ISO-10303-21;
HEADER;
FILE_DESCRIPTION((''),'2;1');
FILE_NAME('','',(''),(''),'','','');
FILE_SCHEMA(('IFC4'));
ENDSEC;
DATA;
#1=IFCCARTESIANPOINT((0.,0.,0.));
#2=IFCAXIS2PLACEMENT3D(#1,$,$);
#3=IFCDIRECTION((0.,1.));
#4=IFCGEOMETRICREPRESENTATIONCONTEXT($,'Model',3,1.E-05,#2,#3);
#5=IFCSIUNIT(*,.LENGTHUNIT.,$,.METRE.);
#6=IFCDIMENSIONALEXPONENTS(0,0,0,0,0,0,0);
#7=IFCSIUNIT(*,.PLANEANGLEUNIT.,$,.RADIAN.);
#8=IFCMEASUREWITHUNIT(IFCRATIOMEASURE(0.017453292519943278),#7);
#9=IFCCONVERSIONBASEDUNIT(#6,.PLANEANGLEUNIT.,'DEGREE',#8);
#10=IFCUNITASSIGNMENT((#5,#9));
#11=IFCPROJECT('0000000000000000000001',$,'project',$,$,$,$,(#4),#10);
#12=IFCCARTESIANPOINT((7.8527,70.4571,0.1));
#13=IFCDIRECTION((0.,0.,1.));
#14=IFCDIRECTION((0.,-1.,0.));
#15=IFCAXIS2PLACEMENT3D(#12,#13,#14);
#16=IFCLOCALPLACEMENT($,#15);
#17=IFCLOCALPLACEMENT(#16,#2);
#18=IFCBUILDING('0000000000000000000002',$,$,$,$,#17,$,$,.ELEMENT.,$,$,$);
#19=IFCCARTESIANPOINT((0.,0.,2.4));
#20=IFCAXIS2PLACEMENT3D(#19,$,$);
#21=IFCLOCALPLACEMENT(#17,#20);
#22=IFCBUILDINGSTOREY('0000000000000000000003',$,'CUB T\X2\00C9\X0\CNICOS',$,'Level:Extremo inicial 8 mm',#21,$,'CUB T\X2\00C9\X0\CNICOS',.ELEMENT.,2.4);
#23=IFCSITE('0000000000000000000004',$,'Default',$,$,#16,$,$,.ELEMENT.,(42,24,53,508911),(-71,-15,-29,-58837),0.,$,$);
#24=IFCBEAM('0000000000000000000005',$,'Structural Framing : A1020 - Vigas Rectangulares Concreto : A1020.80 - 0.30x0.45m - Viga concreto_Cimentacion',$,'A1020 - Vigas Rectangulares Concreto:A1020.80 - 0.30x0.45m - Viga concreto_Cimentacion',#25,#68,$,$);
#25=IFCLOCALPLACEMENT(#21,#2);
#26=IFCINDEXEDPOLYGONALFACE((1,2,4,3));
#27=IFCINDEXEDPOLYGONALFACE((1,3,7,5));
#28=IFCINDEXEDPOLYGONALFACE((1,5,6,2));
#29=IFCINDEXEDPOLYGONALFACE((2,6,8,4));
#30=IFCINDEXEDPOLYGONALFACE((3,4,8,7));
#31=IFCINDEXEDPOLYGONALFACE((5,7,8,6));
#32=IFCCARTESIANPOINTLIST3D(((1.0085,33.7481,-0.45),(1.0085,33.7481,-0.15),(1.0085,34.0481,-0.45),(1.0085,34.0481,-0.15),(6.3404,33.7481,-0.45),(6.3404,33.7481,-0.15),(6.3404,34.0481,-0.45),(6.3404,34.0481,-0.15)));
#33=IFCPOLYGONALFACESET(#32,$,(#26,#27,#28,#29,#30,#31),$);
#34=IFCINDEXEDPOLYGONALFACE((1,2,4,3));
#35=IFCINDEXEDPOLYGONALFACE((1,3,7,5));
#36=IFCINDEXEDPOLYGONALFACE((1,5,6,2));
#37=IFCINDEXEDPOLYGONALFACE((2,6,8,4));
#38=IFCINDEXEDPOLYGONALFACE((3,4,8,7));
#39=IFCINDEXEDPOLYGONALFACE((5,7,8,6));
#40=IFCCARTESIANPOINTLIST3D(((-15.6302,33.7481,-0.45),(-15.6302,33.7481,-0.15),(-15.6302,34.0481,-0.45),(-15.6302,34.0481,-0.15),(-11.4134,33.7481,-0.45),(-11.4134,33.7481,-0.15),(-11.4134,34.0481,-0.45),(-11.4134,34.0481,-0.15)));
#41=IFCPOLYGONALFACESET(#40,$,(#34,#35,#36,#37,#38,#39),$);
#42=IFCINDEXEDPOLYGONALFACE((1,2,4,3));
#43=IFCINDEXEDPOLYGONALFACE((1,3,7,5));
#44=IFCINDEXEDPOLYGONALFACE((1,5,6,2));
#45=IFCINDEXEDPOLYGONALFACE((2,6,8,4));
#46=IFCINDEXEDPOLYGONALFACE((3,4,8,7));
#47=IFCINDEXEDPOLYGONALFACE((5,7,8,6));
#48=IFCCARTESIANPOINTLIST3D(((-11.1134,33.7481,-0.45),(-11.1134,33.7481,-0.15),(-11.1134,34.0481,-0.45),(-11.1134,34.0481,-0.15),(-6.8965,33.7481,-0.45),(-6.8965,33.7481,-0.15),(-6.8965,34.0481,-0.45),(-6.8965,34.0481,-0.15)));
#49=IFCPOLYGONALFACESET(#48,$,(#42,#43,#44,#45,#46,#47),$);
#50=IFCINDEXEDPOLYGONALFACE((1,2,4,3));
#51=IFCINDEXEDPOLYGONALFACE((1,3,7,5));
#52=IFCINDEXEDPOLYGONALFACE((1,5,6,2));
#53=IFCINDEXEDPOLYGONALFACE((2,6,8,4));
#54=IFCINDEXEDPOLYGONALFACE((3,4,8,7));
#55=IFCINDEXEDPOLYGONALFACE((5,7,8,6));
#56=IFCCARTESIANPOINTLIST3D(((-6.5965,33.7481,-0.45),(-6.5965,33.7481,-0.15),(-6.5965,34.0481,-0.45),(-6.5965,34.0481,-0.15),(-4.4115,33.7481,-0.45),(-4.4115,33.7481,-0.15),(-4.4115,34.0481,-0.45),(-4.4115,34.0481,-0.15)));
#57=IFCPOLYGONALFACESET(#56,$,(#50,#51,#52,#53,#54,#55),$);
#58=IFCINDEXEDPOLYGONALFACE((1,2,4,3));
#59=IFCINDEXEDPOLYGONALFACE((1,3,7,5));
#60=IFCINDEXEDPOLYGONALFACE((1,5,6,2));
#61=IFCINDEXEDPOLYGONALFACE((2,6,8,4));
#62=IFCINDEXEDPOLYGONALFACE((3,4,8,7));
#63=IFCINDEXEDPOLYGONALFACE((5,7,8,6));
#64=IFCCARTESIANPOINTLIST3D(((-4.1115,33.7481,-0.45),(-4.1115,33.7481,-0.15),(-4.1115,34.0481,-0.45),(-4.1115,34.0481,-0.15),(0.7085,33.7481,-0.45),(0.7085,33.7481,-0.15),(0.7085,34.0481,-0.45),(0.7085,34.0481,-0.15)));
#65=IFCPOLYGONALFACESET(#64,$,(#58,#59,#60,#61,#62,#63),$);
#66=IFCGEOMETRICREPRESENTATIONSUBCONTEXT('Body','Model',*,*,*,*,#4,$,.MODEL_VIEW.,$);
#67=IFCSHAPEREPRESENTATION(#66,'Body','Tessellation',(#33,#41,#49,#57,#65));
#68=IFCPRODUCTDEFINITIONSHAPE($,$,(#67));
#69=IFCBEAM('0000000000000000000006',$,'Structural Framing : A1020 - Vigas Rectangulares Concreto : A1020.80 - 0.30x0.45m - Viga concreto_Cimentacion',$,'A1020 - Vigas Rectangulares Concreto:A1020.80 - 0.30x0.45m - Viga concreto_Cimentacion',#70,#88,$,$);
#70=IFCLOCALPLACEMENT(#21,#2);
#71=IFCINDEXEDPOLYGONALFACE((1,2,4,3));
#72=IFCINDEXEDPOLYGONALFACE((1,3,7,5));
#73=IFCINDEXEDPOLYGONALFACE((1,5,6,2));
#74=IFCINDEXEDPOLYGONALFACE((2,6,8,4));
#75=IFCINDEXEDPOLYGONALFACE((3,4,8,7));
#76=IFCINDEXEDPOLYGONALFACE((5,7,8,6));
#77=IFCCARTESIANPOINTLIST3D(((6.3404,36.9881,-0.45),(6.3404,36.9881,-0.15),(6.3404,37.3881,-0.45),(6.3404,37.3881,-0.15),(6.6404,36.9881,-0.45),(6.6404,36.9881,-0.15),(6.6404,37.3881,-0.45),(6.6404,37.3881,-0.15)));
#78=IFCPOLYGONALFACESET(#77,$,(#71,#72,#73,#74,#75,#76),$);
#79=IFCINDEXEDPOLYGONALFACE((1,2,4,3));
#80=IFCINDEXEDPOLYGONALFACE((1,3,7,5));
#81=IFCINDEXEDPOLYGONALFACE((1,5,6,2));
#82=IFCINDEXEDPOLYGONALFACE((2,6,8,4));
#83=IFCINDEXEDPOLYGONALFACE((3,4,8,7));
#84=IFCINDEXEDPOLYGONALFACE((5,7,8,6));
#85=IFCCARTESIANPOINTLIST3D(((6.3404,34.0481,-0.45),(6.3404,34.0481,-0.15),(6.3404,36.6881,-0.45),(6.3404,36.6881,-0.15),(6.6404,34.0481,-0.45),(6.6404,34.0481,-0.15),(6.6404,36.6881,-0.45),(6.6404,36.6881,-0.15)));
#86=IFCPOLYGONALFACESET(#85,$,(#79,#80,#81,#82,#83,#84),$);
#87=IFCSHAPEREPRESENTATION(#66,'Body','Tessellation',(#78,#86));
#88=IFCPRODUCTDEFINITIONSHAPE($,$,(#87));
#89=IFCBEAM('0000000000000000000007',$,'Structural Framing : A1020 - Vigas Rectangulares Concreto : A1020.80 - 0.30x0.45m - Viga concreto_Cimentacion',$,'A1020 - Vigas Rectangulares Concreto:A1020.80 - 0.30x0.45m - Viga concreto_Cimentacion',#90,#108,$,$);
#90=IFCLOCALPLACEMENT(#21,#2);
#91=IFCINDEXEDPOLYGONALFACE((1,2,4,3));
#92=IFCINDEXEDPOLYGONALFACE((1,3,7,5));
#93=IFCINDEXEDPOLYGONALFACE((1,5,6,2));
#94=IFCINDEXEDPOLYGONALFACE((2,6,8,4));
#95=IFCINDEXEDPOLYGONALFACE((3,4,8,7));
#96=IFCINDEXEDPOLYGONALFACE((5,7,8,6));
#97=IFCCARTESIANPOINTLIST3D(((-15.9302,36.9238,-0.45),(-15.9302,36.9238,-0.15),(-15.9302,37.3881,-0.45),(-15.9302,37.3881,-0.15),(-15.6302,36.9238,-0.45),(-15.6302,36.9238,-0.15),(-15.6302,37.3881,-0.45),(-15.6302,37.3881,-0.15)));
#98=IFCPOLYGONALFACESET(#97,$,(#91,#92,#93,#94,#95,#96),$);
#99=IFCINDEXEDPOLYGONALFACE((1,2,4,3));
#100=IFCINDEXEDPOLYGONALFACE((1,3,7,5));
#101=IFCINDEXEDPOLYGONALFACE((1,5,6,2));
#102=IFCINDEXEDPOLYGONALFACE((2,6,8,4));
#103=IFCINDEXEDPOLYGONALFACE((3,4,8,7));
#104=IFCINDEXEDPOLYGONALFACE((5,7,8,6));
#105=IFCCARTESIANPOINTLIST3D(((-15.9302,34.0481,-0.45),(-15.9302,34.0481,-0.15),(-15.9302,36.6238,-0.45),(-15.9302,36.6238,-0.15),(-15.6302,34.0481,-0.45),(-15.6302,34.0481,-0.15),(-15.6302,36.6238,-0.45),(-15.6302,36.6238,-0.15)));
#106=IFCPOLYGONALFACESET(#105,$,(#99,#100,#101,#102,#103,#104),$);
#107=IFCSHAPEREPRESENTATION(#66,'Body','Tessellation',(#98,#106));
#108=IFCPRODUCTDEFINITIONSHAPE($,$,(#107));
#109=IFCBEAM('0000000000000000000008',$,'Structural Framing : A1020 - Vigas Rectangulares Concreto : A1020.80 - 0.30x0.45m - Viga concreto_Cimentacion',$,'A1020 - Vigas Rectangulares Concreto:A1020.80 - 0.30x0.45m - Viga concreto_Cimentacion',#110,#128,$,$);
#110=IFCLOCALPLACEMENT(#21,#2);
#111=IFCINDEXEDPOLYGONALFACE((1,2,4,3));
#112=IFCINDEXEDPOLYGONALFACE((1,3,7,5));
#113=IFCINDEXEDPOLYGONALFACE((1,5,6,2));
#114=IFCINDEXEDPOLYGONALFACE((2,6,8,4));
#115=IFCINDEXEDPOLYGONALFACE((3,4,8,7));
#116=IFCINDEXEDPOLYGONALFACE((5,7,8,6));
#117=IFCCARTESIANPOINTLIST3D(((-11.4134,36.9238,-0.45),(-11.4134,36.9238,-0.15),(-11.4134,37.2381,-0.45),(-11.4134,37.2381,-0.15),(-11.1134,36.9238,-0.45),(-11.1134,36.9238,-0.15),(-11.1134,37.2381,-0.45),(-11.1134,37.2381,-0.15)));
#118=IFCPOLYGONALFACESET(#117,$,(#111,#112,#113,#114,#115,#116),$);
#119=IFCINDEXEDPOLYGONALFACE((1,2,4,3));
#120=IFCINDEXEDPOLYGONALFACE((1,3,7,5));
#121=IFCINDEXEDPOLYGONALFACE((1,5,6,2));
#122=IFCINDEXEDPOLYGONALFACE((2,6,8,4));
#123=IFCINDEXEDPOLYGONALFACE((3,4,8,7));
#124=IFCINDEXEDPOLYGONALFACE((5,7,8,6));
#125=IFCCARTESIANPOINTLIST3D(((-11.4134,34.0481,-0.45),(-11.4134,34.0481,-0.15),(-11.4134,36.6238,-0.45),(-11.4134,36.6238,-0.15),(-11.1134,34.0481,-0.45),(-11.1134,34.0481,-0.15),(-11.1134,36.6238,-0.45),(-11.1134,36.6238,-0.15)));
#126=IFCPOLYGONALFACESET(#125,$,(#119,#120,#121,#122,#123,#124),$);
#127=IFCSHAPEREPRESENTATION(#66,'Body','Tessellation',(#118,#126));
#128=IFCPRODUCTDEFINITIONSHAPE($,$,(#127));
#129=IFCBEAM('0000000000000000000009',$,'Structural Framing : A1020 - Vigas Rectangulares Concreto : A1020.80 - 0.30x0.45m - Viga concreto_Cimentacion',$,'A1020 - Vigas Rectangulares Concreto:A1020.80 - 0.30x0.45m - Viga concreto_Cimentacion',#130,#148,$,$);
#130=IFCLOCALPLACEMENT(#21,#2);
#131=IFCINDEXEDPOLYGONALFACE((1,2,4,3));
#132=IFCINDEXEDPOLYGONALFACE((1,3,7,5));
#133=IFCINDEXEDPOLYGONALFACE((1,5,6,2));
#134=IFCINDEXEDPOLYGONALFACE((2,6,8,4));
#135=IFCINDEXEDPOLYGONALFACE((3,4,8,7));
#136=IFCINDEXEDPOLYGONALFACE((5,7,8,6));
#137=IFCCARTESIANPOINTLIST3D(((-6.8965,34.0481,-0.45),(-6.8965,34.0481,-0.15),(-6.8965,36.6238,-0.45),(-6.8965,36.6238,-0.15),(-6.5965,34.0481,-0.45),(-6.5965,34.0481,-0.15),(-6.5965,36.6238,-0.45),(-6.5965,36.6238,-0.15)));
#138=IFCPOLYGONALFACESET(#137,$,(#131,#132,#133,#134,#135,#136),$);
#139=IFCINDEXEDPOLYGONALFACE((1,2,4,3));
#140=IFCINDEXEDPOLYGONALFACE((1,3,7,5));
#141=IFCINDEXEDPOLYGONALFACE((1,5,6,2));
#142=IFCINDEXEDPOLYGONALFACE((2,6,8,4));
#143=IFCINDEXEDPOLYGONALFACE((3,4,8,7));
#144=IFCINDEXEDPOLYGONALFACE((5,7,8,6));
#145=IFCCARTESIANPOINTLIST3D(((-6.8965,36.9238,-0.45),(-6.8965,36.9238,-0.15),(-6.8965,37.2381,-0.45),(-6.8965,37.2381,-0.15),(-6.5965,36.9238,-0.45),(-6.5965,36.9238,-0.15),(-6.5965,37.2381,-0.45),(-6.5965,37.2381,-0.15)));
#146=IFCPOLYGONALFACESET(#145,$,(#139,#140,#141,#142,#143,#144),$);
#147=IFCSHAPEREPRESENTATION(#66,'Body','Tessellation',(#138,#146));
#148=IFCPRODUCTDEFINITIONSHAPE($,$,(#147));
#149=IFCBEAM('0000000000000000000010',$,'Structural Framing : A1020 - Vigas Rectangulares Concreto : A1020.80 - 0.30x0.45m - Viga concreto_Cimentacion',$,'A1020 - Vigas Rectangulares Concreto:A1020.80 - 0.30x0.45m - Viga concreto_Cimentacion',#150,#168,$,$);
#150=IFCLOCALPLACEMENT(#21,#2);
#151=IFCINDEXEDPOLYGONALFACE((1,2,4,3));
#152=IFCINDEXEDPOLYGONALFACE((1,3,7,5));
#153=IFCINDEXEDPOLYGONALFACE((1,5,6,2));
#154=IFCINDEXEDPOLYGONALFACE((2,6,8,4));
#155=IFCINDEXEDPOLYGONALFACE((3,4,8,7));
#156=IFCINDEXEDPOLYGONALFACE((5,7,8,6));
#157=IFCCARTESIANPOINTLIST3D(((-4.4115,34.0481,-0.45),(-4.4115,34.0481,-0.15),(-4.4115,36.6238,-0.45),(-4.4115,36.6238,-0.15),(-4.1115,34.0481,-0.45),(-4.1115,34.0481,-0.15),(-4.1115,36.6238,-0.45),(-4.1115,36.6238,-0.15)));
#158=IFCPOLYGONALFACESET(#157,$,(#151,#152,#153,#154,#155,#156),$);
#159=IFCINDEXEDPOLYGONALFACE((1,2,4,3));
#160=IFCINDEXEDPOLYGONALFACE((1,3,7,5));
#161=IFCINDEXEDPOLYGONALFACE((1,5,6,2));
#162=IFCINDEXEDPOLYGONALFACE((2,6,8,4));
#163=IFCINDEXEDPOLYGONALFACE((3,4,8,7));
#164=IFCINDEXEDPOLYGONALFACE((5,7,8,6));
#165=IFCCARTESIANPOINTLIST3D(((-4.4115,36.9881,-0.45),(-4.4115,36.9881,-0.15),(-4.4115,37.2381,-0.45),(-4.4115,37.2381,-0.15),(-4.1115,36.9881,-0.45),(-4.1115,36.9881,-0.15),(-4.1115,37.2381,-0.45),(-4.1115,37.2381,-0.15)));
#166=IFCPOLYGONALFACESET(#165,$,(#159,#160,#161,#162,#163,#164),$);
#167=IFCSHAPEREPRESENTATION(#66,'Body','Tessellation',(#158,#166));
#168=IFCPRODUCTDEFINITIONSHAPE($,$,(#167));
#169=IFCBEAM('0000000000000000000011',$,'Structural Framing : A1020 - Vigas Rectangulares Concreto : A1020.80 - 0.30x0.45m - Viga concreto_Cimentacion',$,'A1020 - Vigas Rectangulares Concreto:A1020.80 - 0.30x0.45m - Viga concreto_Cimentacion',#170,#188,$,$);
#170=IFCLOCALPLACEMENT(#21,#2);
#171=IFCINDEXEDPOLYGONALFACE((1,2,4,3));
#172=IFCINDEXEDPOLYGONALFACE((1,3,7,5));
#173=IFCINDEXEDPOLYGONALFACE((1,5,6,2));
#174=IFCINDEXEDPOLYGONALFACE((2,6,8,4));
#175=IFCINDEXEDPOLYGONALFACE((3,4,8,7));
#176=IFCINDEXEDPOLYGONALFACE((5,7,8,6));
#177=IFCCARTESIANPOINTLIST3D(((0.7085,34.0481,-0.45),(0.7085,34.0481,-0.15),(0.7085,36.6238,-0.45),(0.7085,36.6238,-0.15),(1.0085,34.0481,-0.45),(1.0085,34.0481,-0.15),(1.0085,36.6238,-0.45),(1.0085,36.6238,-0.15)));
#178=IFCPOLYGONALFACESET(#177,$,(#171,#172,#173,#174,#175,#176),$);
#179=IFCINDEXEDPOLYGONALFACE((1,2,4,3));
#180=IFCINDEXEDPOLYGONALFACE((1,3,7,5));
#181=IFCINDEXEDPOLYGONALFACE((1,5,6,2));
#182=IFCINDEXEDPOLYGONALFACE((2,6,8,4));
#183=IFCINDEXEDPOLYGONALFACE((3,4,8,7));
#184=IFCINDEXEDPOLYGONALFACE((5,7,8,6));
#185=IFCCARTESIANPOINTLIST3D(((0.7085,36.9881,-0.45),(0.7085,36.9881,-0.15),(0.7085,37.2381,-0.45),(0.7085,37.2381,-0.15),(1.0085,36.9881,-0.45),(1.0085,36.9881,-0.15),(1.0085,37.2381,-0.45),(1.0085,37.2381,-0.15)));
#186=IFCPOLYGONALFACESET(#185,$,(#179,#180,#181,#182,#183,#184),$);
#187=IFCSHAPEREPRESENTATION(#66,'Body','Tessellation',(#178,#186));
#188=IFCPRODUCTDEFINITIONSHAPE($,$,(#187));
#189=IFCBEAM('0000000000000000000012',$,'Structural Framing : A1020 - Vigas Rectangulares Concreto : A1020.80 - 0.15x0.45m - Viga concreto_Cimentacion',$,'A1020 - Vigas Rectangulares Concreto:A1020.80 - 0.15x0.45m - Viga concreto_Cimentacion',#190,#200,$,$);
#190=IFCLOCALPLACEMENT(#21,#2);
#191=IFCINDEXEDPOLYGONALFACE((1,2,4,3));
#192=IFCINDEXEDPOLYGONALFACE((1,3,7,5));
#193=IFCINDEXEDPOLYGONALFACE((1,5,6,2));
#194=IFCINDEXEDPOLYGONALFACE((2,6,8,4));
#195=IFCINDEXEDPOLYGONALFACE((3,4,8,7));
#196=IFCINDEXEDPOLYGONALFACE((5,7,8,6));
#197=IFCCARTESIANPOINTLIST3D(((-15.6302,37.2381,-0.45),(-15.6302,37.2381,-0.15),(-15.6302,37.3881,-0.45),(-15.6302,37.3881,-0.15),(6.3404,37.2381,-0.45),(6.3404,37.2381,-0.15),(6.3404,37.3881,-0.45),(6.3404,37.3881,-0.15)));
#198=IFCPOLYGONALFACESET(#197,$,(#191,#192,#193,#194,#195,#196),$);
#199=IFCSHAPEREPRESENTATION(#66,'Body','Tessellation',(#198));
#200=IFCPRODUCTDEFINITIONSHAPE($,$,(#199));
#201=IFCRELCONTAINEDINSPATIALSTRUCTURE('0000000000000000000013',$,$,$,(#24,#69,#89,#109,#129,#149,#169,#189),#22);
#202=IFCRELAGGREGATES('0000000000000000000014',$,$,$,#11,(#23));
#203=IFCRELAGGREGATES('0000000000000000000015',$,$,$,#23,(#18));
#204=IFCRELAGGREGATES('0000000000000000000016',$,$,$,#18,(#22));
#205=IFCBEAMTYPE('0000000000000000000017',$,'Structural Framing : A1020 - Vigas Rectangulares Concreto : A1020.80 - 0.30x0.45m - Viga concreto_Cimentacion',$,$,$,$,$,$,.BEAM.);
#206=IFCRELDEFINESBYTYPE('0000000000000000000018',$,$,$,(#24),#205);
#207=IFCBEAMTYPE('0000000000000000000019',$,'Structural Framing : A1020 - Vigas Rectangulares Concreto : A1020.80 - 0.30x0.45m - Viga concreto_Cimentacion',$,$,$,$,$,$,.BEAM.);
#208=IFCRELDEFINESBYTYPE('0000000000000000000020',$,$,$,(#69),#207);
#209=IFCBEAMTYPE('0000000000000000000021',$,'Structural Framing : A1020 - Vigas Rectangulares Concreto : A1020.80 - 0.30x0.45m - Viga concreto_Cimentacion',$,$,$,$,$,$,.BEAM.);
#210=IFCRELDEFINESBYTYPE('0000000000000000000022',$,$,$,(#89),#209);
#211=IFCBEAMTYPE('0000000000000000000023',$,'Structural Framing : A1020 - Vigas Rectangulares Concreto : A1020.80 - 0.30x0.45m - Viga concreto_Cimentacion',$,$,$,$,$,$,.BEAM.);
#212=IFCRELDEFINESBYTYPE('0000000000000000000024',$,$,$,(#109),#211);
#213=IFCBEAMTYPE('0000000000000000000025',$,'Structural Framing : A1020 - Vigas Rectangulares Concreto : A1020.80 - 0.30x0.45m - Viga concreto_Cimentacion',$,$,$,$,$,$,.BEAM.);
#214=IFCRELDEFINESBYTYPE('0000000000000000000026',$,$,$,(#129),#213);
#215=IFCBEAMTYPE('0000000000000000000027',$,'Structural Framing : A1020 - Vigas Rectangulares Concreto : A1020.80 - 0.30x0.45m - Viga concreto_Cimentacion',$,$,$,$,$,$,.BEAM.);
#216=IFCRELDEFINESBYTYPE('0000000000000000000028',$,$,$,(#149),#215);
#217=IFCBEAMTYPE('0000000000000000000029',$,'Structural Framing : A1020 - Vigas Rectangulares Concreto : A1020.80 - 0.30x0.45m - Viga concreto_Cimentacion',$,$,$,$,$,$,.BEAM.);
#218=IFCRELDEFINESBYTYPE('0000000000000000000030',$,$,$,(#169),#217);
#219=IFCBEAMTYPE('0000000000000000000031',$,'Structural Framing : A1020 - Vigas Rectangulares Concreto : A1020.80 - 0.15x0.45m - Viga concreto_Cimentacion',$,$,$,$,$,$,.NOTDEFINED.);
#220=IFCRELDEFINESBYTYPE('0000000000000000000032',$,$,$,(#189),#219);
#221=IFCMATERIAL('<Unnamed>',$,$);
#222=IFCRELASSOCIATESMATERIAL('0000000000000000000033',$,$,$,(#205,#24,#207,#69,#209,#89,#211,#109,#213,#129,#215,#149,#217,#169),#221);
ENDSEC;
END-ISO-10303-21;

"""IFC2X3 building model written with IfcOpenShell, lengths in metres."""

from ifc_helpers import new_model, entity, si_unit, converted_unit, direction, frame, frame_2d, origin, place, context, subcontext, project, spatial, rectangle, extrude, source, transform, mapped, material, type_object, type_shapes, element, save


model = new_model("IFC2X3")

# Units and contexts
model_context = context("Model", 3, precision=1e-05, world=origin(), true_north=direction((0.0, 1.0)))
body_context = subcontext(model_context, "Body", "Model", "MODEL_VIEW")
ifc_project = project(units=[si_unit("LENGTHUNIT", "METRE"), converted_unit("PLANEANGLEUNIT", "DEGREE", entity("IfcRatioMeasure", 0.017453292519943278), si_unit("PLANEANGLEUNIT", "RADIAN"), dimensions=[0, 0, 0, 0, 0, 0, 0])], contexts=[model_context])

# Site, building, storey
site_placement = place(None, frame((7.8527, 70.4571, 0.1), z_axis=(0.0, 0.0, 1.0), x_axis=(0.0, -1.0, 0.0)))
site = spatial("IfcSite", under=ifc_project, at=site_placement, Name="Default", CompositionType="ELEMENT", RefLatitude=(42, 24, 53, 508911), RefLongitude=(-71, -15, -29, -58837), RefElevation=0.0)
building_placement = place(site_placement, origin())
building = spatial("IfcBuilding", under=site, at=building_placement, CompositionType="ELEMENT")
storey_placement = place(building_placement, frame((0.0, 0.0, 2.4)))
storey = spatial("IfcBuildingStorey", under=building, at=storey_placement, Name="CUB TÉCNICOS", ObjectType="Level:Extremo inicial 8 mm", LongName="CUB TÉCNICOS", CompositionType="ELEMENT", Elevation=2.4)

# Beams
ifc_material_1 = material(Name="<Unnamed>")
beam_type_1 = type_object("IfcBeamType", Name="Structural Framing : A1020 - Vigas Rectangulares Concreto : A1020.80 - 0.30x0.45m - Viga concreto_Cimentacion", PredefinedType="BEAM", material=ifc_material_1)
shared_shape_1 = source(origin(), body_context, "Body", "SweptSolid", [
    extrude(rectangle(XDim=0.3, YDim=0.3, at=frame_2d((0.0, 0.0), x_axis=(1.0, 0.0))), frame((1.0085, 33.8981, 2.1), z_axis=(1.0, 0.0, 0.0), x_axis=(0.0, 0.0, -1.0)), (0.0, 0.0, 1.0), 5.3319),
    extrude(rectangle(XDim=0.3, YDim=0.3, at=frame_2d((0.0, 0.0), x_axis=(1.0, 0.0))), frame((-15.6302, 33.8981, 2.1), z_axis=(1.0, 0.0, 0.0), x_axis=(0.0, 0.0, -1.0)), (0.0, 0.0, 1.0), 4.2168),
    extrude(rectangle(XDim=0.3, YDim=0.3, at=frame_2d((0.0, 0.0), x_axis=(1.0, 0.0))), frame((-11.1134, 33.8981, 2.1), z_axis=(1.0, 0.0, 0.0), x_axis=(0.0, 0.0, -1.0)), (0.0, 0.0, 1.0), 4.2168),
    extrude(rectangle(XDim=0.3, YDim=0.3, at=frame_2d((0.0, 0.0), x_axis=(1.0, 0.0))), frame((-6.5965, 33.8981, 2.1), z_axis=(1.0, 0.0, 0.0), x_axis=(0.0, 0.0, -1.0)), (0.0, 0.0, 1.0), 2.185),
    extrude(rectangle(XDim=0.3, YDim=0.3, at=frame_2d((0.0, 0.0), x_axis=(1.0, 0.0))), frame((-4.1115, 33.8981, 2.1), z_axis=(1.0, 0.0, 0.0), x_axis=(0.0, 0.0, -1.0)), (0.0, 0.0, 1.0), 4.82),
])
type_shapes(beam_type_1, [shared_shape_1])
beam_1_placement = place(storey_placement, frame((0.0, 0.0, -2.4)))
element("IfcBeam", 1, at=beam_1_placement, inside=storey, type_object=beam_type_1, material=ifc_material_1, Name="Structural Framing : A1020 - Vigas Rectangulares Concreto : A1020.80 - 0.30x0.45m - Viga concreto_Cimentacion", ObjectType="A1020 - Vigas Rectangulares Concreto:A1020.80 - 0.30x0.45m - Viga concreto_Cimentacion", context=body_context, shape_type="MappedRepresentation", body=[
    mapped(shared_shape_1, transform((0.0, 0.0, 0.0), scale=1.0)),
])
beam_type_2 = type_object("IfcBeamType", Name="Structural Framing : A1020 - Vigas Rectangulares Concreto : A1020.80 - 0.30x0.45m - Viga concreto_Cimentacion", PredefinedType="BEAM", material=ifc_material_1)
shared_shape_2 = source(origin(), body_context, "Body", "SweptSolid", [
    extrude(rectangle(XDim=0.3, YDim=0.3, at=frame_2d((0.0, 0.0), x_axis=(0.0, 1.0))), frame((6.4904, 36.9881, 2.1), z_axis=(0.0, 1.0, 0.0), x_axis=(-1.0, 0.0, 0.0)), (0.0, 0.0, 1.0), 0.4),
    extrude(rectangle(XDim=0.3, YDim=0.3, at=frame_2d((0.0, 0.0), x_axis=(0.0, 1.0))), frame((6.4904, 34.0481, 2.1), z_axis=(0.0, 1.0, 0.0), x_axis=(-1.0, 0.0, 0.0)), (0.0, 0.0, 1.0), 2.6399),
])
type_shapes(beam_type_2, [shared_shape_2])
beam_2_placement = place(storey_placement, frame((0.0, 0.0, -2.4)))
element("IfcBeam", 2, at=beam_2_placement, inside=storey, type_object=beam_type_2, material=ifc_material_1, Name="Structural Framing : A1020 - Vigas Rectangulares Concreto : A1020.80 - 0.30x0.45m - Viga concreto_Cimentacion", ObjectType="A1020 - Vigas Rectangulares Concreto:A1020.80 - 0.30x0.45m - Viga concreto_Cimentacion", context=body_context, shape_type="MappedRepresentation", body=[
    mapped(shared_shape_2, transform((0.0, 0.0, 0.0), scale=1.0)),
])
beam_type_3 = type_object("IfcBeamType", Name="Structural Framing : A1020 - Vigas Rectangulares Concreto : A1020.80 - 0.30x0.45m - Viga concreto_Cimentacion", PredefinedType="BEAM", material=ifc_material_1)
shared_shape_3 = source(origin(), body_context, "Body", "SweptSolid", [
    extrude(rectangle(XDim=0.3, YDim=0.3, at=frame_2d((0.0, 0.0), x_axis=(0.0, 1.0))), frame((-15.7802, 36.9238, 2.1), z_axis=(0.0, 1.0, 0.0), x_axis=(-1.0, 0.0, 0.0)), (0.0, 0.0, 1.0), 0.4642),
    extrude(rectangle(XDim=0.3, YDim=0.3, at=frame_2d((0.0, 0.0), x_axis=(0.0, 1.0))), frame((-15.7802, 34.0481, 2.1), z_axis=(0.0, 1.0, 0.0), x_axis=(-1.0, 0.0, 0.0)), (0.0, 0.0, 1.0), 2.5757),
])
type_shapes(beam_type_3, [shared_shape_3])
beam_3_placement = place(storey_placement, frame((0.0, 0.0, -2.4)))
element("IfcBeam", 3, at=beam_3_placement, inside=storey, type_object=beam_type_3, material=ifc_material_1, Name="Structural Framing : A1020 - Vigas Rectangulares Concreto : A1020.80 - 0.30x0.45m - Viga concreto_Cimentacion", ObjectType="A1020 - Vigas Rectangulares Concreto:A1020.80 - 0.30x0.45m - Viga concreto_Cimentacion", context=body_context, shape_type="MappedRepresentation", body=[
    mapped(shared_shape_3, transform((0.0, 0.0, 0.0), scale=1.0)),
])
beam_type_4 = type_object("IfcBeamType", Name="Structural Framing : A1020 - Vigas Rectangulares Concreto : A1020.80 - 0.30x0.45m - Viga concreto_Cimentacion", PredefinedType="BEAM", material=ifc_material_1)
shared_shape_4 = source(origin(), body_context, "Body", "SweptSolid", [
    extrude(rectangle(XDim=0.3, YDim=0.3, at=frame_2d((0.0, 0.0), x_axis=(0.0, 1.0))), frame((-11.2634, 36.9238, 2.1), z_axis=(0.0, 1.0, 0.0), x_axis=(-1.0, 0.0, 0.0)), (0.0, 0.0, 1.0), 0.3142),
    extrude(rectangle(XDim=0.3, YDim=0.3, at=frame_2d((0.0, 0.0), x_axis=(0.0, 1.0))), frame((-11.2634, 34.0481, 2.1), z_axis=(0.0, 1.0, 0.0), x_axis=(-1.0, 0.0, 0.0)), (0.0, 0.0, 1.0), 2.5757),
])
type_shapes(beam_type_4, [shared_shape_4])
beam_4_placement = place(storey_placement, frame((0.0, 0.0, -2.4)))
element("IfcBeam", 4, at=beam_4_placement, inside=storey, type_object=beam_type_4, material=ifc_material_1, Name="Structural Framing : A1020 - Vigas Rectangulares Concreto : A1020.80 - 0.30x0.45m - Viga concreto_Cimentacion", ObjectType="A1020 - Vigas Rectangulares Concreto:A1020.80 - 0.30x0.45m - Viga concreto_Cimentacion", context=body_context, shape_type="MappedRepresentation", body=[
    mapped(shared_shape_4, transform((0.0, 0.0, 0.0), scale=1.0)),
])
beam_type_5 = type_object("IfcBeamType", Name="Structural Framing : A1020 - Vigas Rectangulares Concreto : A1020.80 - 0.30x0.45m - Viga concreto_Cimentacion", PredefinedType="BEAM", material=ifc_material_1)
shared_shape_5 = source(origin(), body_context, "Body", "SweptSolid", [
    extrude(rectangle(XDim=0.3, YDim=0.3, at=frame_2d((0.0, 0.0), x_axis=(0.0, 1.0))), frame((-6.7465, 34.0481, 2.1), z_axis=(0.0, 1.0, 0.0), x_axis=(-1.0, 0.0, 0.0)), (0.0, 0.0, 1.0), 2.5757),
    extrude(rectangle(XDim=0.3, YDim=0.3, at=frame_2d((0.0, 0.0), x_axis=(0.0, 1.0))), frame((-6.7465, 36.9238, 2.1), z_axis=(0.0, 1.0, 0.0), x_axis=(-1.0, 0.0, 0.0)), (0.0, 0.0, 1.0), 0.3142),
])
type_shapes(beam_type_5, [shared_shape_5])
beam_5_placement = place(storey_placement, frame((0.0, 0.0, -2.4)))
element("IfcBeam", 5, at=beam_5_placement, inside=storey, type_object=beam_type_5, material=ifc_material_1, Name="Structural Framing : A1020 - Vigas Rectangulares Concreto : A1020.80 - 0.30x0.45m - Viga concreto_Cimentacion", ObjectType="A1020 - Vigas Rectangulares Concreto:A1020.80 - 0.30x0.45m - Viga concreto_Cimentacion", context=body_context, shape_type="MappedRepresentation", body=[
    mapped(shared_shape_5, transform((0.0, 0.0, 0.0), scale=1.0)),
])
beam_type_6 = type_object("IfcBeamType", Name="Structural Framing : A1020 - Vigas Rectangulares Concreto : A1020.80 - 0.30x0.45m - Viga concreto_Cimentacion", PredefinedType="BEAM", material=ifc_material_1)
shared_shape_6 = source(origin(), body_context, "Body", "SweptSolid", [
    extrude(rectangle(XDim=0.3, YDim=0.3, at=frame_2d((0.0, 0.0), x_axis=(0.0, 1.0))), frame((-4.2615, 34.0481, 2.1), z_axis=(0.0, 1.0, 0.0), x_axis=(-1.0, 0.0, 0.0)), (0.0, 0.0, 1.0), 2.5757),
    extrude(rectangle(XDim=0.3, YDim=0.3, at=frame_2d((0.0, 0.0), x_axis=(0.0, 1.0))), frame((-4.2615, 36.9881, 2.1), z_axis=(0.0, 1.0, 0.0), x_axis=(-1.0, 0.0, 0.0)), (0.0, 0.0, 1.0), 0.25),
])
type_shapes(beam_type_6, [shared_shape_6])
beam_6_placement = place(storey_placement, frame((0.0, 0.0, -2.4)))
element("IfcBeam", 6, at=beam_6_placement, inside=storey, type_object=beam_type_6, material=ifc_material_1, Name="Structural Framing : A1020 - Vigas Rectangulares Concreto : A1020.80 - 0.30x0.45m - Viga concreto_Cimentacion", ObjectType="A1020 - Vigas Rectangulares Concreto:A1020.80 - 0.30x0.45m - Viga concreto_Cimentacion", context=body_context, shape_type="MappedRepresentation", body=[
    mapped(shared_shape_6, transform((0.0, 0.0, 0.0), scale=1.0)),
])
beam_type_7 = type_object("IfcBeamType", Name="Structural Framing : A1020 - Vigas Rectangulares Concreto : A1020.80 - 0.30x0.45m - Viga concreto_Cimentacion", PredefinedType="BEAM", material=ifc_material_1)
shared_shape_7 = source(origin(), body_context, "Body", "SweptSolid", [
    extrude(rectangle(XDim=0.3, YDim=0.3, at=frame_2d((0.0, 0.0), x_axis=(0.0, 1.0))), frame((0.8585, 34.0481, 2.1), z_axis=(0.0, 1.0, 0.0), x_axis=(-1.0, 0.0, 0.0)), (0.0, 0.0, 1.0), 2.5757),
    extrude(rectangle(XDim=0.3, YDim=0.3, at=frame_2d((0.0, 0.0), x_axis=(0.0, 1.0))), frame((0.8585, 36.9881, 2.1), z_axis=(0.0, 1.0, 0.0), x_axis=(-1.0, 0.0, 0.0)), (0.0, 0.0, 1.0), 0.25),
])
type_shapes(beam_type_7, [shared_shape_7])
beam_7_placement = place(storey_placement, frame((0.0, 0.0, -2.4)))
element("IfcBeam", 7, at=beam_7_placement, inside=storey, type_object=beam_type_7, material=ifc_material_1, Name="Structural Framing : A1020 - Vigas Rectangulares Concreto : A1020.80 - 0.30x0.45m - Viga concreto_Cimentacion", ObjectType="A1020 - Vigas Rectangulares Concreto:A1020.80 - 0.30x0.45m - Viga concreto_Cimentacion", context=body_context, shape_type="MappedRepresentation", body=[
    mapped(shared_shape_7, transform((0.0, 0.0, 0.0), scale=1.0)),
])
beam_type_8 = type_object("IfcBeamType", Name="Structural Framing : A1020 - Vigas Rectangulares Concreto : A1020.80 - 0.15x0.45m - Viga concreto_Cimentacion", PredefinedType="NOTDEFINED")
beam_8_placement = place(storey_placement, frame((-15.7802, 37.3131, 0.0)))
element("IfcBeam", 8, at=beam_8_placement, inside=storey, type_object=beam_type_8, Name="Structural Framing : A1020 - Vigas Rectangulares Concreto : A1020.80 - 0.15x0.45m - Viga concreto_Cimentacion", ObjectType="A1020 - Vigas Rectangulares Concreto:A1020.80 - 0.15x0.45m - Viga concreto_Cimentacion", context=body_context, shape_type="SweptSolid", body=[
    extrude(rectangle(XDim=0.3, YDim=0.15, at=frame_2d((0.0, 0.0), x_axis=(1.0, 0.0))), frame((0.15, 0.0, -0.3), z_axis=(1.0, 0.0, 0.0), x_axis=(0.0, 0.0, -1.0)), (0.0, 0.0, 1.0), 21.9706),
])

save(model, "model.ifc")
